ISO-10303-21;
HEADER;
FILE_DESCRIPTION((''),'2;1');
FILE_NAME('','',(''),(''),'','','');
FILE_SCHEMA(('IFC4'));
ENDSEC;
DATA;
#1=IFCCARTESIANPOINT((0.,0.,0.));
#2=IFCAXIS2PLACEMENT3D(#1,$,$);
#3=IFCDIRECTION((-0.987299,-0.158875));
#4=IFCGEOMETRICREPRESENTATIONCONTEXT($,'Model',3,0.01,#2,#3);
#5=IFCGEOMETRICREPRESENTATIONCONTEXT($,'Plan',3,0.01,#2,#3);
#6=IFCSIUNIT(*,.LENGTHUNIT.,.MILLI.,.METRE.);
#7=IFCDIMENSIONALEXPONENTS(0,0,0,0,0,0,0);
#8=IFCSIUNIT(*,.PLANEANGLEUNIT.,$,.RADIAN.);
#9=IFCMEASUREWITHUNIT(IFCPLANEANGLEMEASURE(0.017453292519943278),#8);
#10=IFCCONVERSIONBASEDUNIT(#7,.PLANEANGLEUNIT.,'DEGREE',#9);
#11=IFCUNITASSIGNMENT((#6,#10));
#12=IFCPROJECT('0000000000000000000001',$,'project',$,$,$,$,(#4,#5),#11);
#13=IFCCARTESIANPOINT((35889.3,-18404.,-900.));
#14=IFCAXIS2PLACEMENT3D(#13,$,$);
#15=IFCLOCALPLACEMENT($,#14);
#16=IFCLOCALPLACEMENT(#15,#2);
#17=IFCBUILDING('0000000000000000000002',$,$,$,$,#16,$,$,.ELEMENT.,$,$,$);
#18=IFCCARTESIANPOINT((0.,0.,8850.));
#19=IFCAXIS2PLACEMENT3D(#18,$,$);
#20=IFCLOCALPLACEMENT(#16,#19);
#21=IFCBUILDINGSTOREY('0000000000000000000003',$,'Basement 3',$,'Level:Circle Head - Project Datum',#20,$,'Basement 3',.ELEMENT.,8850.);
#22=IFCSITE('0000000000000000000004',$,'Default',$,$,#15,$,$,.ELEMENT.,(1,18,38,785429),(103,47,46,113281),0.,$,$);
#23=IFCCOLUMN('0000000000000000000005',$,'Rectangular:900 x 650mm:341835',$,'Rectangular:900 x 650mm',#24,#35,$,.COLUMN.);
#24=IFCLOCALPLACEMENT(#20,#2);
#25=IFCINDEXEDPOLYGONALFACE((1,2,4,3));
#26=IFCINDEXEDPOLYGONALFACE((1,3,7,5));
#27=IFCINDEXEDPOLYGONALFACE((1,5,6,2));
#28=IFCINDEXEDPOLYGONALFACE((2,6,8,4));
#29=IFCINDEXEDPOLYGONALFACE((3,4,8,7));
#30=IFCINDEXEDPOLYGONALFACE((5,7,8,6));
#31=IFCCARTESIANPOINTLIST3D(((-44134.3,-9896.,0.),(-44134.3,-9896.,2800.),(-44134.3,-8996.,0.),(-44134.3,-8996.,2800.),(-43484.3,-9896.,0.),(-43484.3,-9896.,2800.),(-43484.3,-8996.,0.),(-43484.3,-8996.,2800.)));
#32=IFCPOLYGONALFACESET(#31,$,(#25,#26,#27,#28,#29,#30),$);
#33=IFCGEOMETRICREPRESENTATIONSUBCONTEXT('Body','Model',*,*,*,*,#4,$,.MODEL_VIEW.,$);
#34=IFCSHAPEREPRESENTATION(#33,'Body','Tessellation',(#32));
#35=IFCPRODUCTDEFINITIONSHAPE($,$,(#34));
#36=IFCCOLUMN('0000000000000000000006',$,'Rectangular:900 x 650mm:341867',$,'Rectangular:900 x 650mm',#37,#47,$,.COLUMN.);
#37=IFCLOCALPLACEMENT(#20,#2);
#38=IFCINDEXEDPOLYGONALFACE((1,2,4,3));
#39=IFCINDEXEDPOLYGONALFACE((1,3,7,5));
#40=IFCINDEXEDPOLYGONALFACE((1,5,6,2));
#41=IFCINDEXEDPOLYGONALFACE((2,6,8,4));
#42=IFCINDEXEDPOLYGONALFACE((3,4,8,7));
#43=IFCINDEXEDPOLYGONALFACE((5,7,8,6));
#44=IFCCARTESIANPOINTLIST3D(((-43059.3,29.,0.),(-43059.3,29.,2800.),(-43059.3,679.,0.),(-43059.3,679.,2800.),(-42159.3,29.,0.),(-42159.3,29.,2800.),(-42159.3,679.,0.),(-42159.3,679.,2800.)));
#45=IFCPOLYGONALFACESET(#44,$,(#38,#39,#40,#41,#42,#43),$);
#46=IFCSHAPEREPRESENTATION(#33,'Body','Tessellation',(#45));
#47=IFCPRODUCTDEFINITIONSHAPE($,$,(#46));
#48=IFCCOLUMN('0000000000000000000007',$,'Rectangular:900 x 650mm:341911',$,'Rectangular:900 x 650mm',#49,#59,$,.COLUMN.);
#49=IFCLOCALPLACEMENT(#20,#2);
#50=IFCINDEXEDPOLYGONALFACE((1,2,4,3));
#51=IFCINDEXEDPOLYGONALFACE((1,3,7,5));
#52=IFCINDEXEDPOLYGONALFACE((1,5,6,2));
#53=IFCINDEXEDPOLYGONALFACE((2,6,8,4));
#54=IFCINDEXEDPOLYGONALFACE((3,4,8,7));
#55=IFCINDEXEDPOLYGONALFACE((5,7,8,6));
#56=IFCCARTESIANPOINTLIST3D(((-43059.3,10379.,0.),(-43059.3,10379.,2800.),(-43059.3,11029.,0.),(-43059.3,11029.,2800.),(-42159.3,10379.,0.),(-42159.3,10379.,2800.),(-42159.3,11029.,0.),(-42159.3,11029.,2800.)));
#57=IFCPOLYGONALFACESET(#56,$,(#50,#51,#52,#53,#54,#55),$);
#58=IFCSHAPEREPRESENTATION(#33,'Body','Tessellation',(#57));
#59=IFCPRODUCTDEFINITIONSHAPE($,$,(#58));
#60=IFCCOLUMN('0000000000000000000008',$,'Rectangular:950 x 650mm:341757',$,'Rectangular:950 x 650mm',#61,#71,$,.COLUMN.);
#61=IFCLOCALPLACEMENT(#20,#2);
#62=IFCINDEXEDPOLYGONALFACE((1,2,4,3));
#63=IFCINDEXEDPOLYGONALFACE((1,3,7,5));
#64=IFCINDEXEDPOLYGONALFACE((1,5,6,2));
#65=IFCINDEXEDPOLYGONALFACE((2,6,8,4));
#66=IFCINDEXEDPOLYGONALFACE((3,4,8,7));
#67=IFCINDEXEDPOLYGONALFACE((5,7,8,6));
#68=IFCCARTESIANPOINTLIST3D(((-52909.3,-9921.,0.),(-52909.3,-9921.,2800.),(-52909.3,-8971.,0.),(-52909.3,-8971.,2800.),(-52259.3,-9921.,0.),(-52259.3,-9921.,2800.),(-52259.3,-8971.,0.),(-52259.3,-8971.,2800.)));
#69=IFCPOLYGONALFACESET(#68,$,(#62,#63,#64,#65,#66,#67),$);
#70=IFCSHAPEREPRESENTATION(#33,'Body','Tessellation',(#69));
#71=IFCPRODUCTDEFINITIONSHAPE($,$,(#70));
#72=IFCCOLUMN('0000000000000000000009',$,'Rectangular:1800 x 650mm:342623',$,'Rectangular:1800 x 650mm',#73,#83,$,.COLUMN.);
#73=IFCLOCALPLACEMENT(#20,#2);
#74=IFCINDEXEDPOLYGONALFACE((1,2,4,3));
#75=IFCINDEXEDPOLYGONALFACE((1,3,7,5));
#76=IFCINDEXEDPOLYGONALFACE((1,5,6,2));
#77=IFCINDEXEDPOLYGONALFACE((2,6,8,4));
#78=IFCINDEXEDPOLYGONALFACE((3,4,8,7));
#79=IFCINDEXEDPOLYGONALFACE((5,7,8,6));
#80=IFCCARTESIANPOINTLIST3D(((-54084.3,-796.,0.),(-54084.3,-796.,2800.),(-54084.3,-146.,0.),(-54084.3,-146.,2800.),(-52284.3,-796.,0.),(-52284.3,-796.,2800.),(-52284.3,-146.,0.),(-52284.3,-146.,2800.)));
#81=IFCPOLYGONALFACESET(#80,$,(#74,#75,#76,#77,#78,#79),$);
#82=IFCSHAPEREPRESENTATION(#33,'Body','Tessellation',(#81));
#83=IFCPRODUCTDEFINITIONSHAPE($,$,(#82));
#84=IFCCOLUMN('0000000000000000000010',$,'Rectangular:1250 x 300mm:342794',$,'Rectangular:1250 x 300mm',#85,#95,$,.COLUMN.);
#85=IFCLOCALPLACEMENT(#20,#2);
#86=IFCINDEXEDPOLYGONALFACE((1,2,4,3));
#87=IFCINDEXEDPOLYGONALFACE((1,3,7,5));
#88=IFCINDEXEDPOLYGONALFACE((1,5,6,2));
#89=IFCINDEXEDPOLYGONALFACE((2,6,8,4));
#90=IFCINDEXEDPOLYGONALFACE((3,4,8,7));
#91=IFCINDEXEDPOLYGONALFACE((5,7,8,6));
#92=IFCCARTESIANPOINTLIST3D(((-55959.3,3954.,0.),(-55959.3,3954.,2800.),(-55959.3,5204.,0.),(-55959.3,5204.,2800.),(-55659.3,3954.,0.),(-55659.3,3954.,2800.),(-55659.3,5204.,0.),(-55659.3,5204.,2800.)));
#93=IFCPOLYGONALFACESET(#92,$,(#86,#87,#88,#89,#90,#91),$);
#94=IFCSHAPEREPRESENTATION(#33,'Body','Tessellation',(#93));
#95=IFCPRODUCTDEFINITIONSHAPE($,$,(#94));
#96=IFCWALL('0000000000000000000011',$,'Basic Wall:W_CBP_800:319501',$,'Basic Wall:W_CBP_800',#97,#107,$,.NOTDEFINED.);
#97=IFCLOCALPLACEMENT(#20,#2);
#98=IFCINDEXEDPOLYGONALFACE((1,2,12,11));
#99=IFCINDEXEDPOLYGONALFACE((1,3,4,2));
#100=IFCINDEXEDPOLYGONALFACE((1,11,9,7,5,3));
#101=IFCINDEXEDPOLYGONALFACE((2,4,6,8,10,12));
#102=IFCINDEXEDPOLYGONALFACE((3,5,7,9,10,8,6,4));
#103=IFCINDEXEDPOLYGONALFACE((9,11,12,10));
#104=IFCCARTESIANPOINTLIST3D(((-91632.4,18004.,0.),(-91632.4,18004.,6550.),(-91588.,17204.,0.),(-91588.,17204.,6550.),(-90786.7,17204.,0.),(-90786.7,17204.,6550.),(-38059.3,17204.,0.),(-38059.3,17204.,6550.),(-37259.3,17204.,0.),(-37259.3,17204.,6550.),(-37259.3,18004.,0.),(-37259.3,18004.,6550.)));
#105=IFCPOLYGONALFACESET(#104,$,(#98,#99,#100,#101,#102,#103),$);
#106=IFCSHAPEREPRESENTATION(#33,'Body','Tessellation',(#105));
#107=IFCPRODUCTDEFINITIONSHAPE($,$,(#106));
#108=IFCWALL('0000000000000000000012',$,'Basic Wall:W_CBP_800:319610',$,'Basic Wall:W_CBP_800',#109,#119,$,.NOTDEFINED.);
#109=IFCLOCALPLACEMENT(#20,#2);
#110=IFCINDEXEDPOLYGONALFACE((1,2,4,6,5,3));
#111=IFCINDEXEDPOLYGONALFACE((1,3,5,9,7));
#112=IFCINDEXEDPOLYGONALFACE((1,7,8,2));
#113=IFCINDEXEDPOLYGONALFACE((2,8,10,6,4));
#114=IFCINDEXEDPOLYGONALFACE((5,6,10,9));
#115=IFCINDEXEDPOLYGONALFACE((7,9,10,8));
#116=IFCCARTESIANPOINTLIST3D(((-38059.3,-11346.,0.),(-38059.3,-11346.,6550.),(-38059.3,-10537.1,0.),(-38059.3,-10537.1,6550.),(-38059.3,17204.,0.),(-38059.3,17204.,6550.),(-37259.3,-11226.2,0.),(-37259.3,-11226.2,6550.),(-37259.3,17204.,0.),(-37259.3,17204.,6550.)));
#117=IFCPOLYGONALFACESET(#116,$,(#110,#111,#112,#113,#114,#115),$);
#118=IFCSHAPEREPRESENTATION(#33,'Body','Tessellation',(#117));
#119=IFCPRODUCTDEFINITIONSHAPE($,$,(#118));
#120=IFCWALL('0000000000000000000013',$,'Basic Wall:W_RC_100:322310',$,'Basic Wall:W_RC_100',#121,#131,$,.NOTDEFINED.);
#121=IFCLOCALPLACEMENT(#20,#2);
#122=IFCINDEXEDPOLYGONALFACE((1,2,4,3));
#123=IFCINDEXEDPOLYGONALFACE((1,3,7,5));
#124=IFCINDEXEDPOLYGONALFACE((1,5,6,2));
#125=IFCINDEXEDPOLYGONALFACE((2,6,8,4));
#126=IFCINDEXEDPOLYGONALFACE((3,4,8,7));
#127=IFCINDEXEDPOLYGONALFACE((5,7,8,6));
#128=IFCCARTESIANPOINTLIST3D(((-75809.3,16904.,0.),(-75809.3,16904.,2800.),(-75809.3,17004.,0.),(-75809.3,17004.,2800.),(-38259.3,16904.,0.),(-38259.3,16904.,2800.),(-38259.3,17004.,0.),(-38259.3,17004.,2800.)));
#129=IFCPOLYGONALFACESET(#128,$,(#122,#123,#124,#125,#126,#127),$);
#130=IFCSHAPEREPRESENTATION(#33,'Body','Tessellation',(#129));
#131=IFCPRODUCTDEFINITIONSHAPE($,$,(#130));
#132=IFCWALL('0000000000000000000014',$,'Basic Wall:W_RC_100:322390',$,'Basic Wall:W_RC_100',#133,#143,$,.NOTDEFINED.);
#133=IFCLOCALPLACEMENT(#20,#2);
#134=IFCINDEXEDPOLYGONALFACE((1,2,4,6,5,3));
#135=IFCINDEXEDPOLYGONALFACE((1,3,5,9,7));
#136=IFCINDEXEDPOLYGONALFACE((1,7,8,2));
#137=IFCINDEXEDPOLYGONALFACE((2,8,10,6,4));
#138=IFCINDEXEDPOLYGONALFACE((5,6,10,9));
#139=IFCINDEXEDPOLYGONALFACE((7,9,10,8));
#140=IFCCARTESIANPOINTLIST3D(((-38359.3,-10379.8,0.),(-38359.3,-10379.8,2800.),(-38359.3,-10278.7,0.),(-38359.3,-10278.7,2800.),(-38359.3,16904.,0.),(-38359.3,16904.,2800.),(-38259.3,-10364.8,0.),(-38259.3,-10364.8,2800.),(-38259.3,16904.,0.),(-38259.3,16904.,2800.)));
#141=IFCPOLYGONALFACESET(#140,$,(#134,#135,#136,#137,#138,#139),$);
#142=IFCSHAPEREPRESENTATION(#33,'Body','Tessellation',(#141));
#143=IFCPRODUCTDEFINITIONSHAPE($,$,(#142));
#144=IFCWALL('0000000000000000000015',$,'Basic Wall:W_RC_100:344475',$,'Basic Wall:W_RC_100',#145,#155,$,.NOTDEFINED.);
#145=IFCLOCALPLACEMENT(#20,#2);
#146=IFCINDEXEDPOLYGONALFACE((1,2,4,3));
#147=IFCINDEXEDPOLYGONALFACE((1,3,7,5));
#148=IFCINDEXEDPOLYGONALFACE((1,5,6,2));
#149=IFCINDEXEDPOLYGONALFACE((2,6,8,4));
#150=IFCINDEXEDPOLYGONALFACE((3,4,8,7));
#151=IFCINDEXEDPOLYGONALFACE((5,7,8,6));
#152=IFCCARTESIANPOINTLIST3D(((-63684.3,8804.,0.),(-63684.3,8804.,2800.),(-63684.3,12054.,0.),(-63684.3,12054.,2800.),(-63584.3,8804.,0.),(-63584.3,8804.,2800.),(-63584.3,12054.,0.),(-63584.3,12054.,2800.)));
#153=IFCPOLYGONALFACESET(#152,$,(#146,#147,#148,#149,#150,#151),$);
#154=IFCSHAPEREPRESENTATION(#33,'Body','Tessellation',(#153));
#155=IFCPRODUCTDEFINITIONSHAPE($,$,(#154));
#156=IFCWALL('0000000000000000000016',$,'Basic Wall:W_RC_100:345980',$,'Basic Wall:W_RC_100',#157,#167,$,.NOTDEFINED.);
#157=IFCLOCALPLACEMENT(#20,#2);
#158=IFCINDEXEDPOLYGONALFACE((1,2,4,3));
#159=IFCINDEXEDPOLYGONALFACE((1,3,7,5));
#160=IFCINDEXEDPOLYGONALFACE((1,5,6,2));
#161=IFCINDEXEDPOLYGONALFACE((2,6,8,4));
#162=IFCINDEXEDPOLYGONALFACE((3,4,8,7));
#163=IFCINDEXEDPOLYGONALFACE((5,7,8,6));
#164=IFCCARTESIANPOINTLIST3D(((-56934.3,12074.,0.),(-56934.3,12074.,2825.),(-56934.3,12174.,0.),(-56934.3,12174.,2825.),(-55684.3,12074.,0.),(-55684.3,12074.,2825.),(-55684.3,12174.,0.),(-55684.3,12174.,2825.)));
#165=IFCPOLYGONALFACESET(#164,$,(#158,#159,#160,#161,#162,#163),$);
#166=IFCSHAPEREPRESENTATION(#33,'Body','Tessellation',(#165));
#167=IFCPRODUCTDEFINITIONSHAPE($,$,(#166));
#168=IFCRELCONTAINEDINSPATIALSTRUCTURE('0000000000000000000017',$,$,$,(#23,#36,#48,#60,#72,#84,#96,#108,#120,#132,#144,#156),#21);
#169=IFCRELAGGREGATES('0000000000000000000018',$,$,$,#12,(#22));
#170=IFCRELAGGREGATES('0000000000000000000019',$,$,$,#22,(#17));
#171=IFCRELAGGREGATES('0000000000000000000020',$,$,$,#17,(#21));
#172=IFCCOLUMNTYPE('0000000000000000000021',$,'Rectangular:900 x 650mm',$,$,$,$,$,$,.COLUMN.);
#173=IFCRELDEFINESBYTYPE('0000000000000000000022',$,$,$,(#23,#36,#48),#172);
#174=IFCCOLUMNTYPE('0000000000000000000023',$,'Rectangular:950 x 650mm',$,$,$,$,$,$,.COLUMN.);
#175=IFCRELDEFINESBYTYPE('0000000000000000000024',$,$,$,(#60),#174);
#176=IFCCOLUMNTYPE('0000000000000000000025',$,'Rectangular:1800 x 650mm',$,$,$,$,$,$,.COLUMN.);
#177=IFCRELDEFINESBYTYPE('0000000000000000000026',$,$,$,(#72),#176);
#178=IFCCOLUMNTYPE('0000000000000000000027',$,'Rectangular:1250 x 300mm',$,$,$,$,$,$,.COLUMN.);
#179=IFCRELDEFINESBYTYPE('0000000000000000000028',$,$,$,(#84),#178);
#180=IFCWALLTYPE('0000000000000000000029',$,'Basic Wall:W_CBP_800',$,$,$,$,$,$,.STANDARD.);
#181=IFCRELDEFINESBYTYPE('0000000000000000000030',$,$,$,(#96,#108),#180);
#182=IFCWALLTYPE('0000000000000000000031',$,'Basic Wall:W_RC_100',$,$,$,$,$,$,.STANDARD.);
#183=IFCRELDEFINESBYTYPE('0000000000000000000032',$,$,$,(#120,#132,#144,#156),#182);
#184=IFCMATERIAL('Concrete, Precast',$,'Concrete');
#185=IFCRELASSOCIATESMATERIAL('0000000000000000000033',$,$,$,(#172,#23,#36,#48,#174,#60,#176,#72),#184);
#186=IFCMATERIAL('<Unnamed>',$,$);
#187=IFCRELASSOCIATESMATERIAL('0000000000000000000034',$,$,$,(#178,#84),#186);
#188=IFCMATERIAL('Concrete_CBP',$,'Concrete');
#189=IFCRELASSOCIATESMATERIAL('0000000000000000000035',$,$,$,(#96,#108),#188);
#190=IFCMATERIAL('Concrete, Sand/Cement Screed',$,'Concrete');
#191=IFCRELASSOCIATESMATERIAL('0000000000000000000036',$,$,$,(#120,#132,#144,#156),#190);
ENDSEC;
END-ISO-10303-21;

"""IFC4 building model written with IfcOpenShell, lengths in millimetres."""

from ifc_helpers import new_model, entity, si_unit, converted_unit, direction, frame, origin, place, context, subcontext, project, spatial, indexed_curve, outline, extrude, source, transform, mapped, material, type_object, type_shapes, element, save


model = new_model("IFC4")

# Units and contexts
model_context = context("Model", 3, precision=0.01, world=origin(), true_north=direction((-0.987299, -0.158875)))
plan_context = context("Plan", 3, precision=0.01, world=origin(), true_north=direction((-0.987299, -0.158875)))
body_context = subcontext(model_context, "Body", "Model", "MODEL_VIEW")
ifc_project = project(units=[si_unit("LENGTHUNIT", "METRE", prefix="MILLI"), converted_unit("PLANEANGLEUNIT", "DEGREE", entity("IfcPlaneAngleMeasure", 0.017453292519943278), si_unit("PLANEANGLEUNIT", "RADIAN"), dimensions=[0, 0, 0, 0, 0, 0, 0])], contexts=[model_context, plan_context])

# Site, building, storey
site_placement = place(None, frame((35889.3, -18404.0, -900.0)))
site = spatial("IfcSite", under=ifc_project, at=site_placement, Name="Default", CompositionType="ELEMENT", RefLatitude=(1, 18, 38, 785429), RefLongitude=(103, 47, 46, 113281), RefElevation=0.0)
building_placement = place(site_placement, origin())
building = spatial("IfcBuilding", under=site, at=building_placement, CompositionType="ELEMENT")
storey_placement = place(building_placement, frame((0.0, 0.0, 8850.0)))
storey = spatial("IfcBuildingStorey", under=building, at=storey_placement, Name="Basement 3", ObjectType="Level:Circle Head - Project Datum", LongName="Basement 3", CompositionType="ELEMENT", Elevation=8850.0)

# Columns
ifc_material_1 = material(Name="Concrete, Precast", Category="Concrete")
column_type_1 = type_object("IfcColumnType", Name="Rectangular:900 x 650mm", PredefinedType="COLUMN", material=ifc_material_1)
shared_shape_1 = source(origin(), body_context, "Body", "SweptSolid", [
    extrude(outline(indexed_curve([(-325.0, -450.0), (325.0, -450.0), (325.0, 450.0), (-325.0, 450.0), (-325.0, -450.0)], self_intersect=False)), frame((0.0, 0.0, 8850.0), z_axis=(0.0, 0.0, 1.0), x_axis=(-1.0, 0.0, 0.0)), (0.0, 0.0, 1.0), 2800.0),
])
type_shapes(column_type_1, [shared_shape_1])
column_1_placement = place(storey_placement, frame((-43809.3, -9446.0, -8850.0)))
element("IfcColumn", 1, at=column_1_placement, inside=storey, type_object=column_type_1, material=ifc_material_1, Name="Rectangular:900 x 650mm:341835", ObjectType="Rectangular:900 x 650mm", PredefinedType="COLUMN", context=body_context, shape_type="MappedRepresentation", body=[
    mapped(shared_shape_1, transform((0.0, 0.0, 0.0), scale=1.0)),
])
for number, where, z_axis, x_axis, name in (
    (2, (-42609.3, 354.0, -8850.0), (0.0, 0.0, 1.0), (0.0, 1.0, 0.0), "Rectangular:900 x 650mm:341867"),
    (3, (-42609.3, 10704.0, -8850.0), (0.0, 0.0, 1.0), (0.0, 1.0, 0.0), "Rectangular:900 x 650mm:341911"),
):
    element("IfcColumn", number, at=place(storey_placement, frame(where, z_axis=z_axis, x_axis=x_axis)), inside=storey, type_object=column_type_1, material=ifc_material_1, Name=name, ObjectType="Rectangular:900 x 650mm", PredefinedType="COLUMN", context=body_context, shape_type="MappedRepresentation", body=[
        mapped(shared_shape_1, transform((0.0, 0.0, 0.0), scale=1.0)),
    ])
column_type_2 = type_object("IfcColumnType", Name="Rectangular:950 x 650mm", PredefinedType="COLUMN", material=ifc_material_1)
shared_shape_2 = source(origin(), body_context, "Body", "SweptSolid", [
    extrude(outline(indexed_curve([(-325.0, -475.0), (325.0, -475.0), (325.0, 475.0), (-325.0, 475.0), (-325.0, -475.0)], self_intersect=False)), frame((0.0, 0.0, 8850.0), z_axis=(0.0, 0.0, 1.0), x_axis=(-1.0, 0.0, 0.0)), (0.0, 0.0, 1.0), 2800.0),
])
type_shapes(column_type_2, [shared_shape_2])
column_2_placement = place(storey_placement, frame((-52584.3, -9446.0, -8850.0)))
element("IfcColumn", 4, at=column_2_placement, inside=storey, type_object=column_type_2, material=ifc_material_1, Name="Rectangular:950 x 650mm:341757", ObjectType="Rectangular:950 x 650mm", PredefinedType="COLUMN", context=body_context, shape_type="MappedRepresentation", body=[
    mapped(shared_shape_2, transform((0.0, 0.0, 0.0), scale=1.0)),
])
column_type_3 = type_object("IfcColumnType", Name="Rectangular:1800 x 650mm", PredefinedType="COLUMN", material=ifc_material_1)
shared_shape_3 = source(origin(), body_context, "Body", "SweptSolid", [
    extrude(outline(indexed_curve([(-325.0, -900.0), (325.0, -900.0), (325.0, 900.0), (-325.0, 900.0), (-325.0, -900.0)], self_intersect=False)), frame((0.0, 0.0, 8850.0), z_axis=(0.0, 0.0, 1.0), x_axis=(-1.0, 0.0, 0.0)), (0.0, 0.0, 1.0), 2800.0),
])
type_shapes(column_type_3, [shared_shape_3])
column_3_placement = place(storey_placement, frame((-53184.3, -471.0, -8850.0), z_axis=(0.0, 0.0, 1.0), x_axis=(0.0, 1.0, 0.0)))
element("IfcColumn", 5, at=column_3_placement, inside=storey, type_object=column_type_3, material=ifc_material_1, Name="Rectangular:1800 x 650mm:342623", ObjectType="Rectangular:1800 x 650mm", PredefinedType="COLUMN", context=body_context, shape_type="MappedRepresentation", body=[
    mapped(shared_shape_3, transform((0.0, 0.0, 0.0), scale=1.0)),
])
ifc_material_2 = material(Name="<Unnamed>")
column_type_4 = type_object("IfcColumnType", Name="Rectangular:1250 x 300mm", PredefinedType="COLUMN", material=ifc_material_2)
shared_shape_4 = source(origin(), body_context, "Body", "SweptSolid", [
    extrude(outline(indexed_curve([(-150.0, -625.0), (150.0, -625.0), (150.0, 625.0), (-150.0, 625.0), (-150.0, -625.0)], self_intersect=False)), frame((0.0, 0.0, 8850.0), z_axis=(0.0, 0.0, 1.0), x_axis=(-1.0, 0.0, 0.0)), (0.0, 0.0, 1.0), 2800.0),
])
type_shapes(column_type_4, [shared_shape_4])
column_4_placement = place(storey_placement, frame((-55809.3, 4579.0, -8850.0), z_axis=(0.0, 0.0, 1.0), x_axis=(-1.0, 0.0, 0.0)))
element("IfcColumn", 6, at=column_4_placement, inside=storey, type_object=column_type_4, material=ifc_material_2, Name="Rectangular:1250 x 300mm:342794", ObjectType="Rectangular:1250 x 300mm", PredefinedType="COLUMN", context=body_context, shape_type="MappedRepresentation", body=[
    mapped(shared_shape_4, transform((0.0, 0.0, 0.0), scale=1.0)),
])

# Walls
ifc_material_3 = material(Name="Concrete_CBP", Category="Concrete")
wall_type_1 = type_object("IfcWallType", Name="Basic Wall:W_CBP_800", PredefinedType="STANDARD")
wall_1_placement = place(storey_placement, frame((-37259.3, 17604.0, 0.0), z_axis=(0.0, 0.0, 1.0), x_axis=(-1.0, 0.0, 0.0)))
element("IfcWall", 7, at=wall_1_placement, inside=storey, type_object=wall_type_1, material=ifc_material_3, Name="Basic Wall:W_CBP_800:319501", ObjectType="Basic Wall:W_CBP_800", PredefinedType="NOTDEFINED", context=body_context, shape_type="SweptSolid", body=[
    extrude(outline(indexed_curve([(54373.1, -400.0), (54328.6, 400.0), (53527.4, 400.0), (800.0, 400.0), (0.0, 400.0), (0.0, -400.0), (54373.1, -400.0)], self_intersect=False)), origin(), (0.0, 0.0, 1.0), 6550.0),
])
wall_2_placement = place(storey_placement, frame((-37659.3, 17204.0, 0.0), z_axis=(0.0, 0.0, 1.0), x_axis=(0.0, -1.0, 0.0)))
element("IfcWall", 8, at=wall_2_placement, inside=storey, type_object=wall_type_1, material=ifc_material_3, Name="Basic Wall:W_CBP_800:319610", ObjectType="Basic Wall:W_CBP_800", PredefinedType="NOTDEFINED", context=body_context, shape_type="SweptSolid", body=[
    extrude(outline(indexed_curve([(28550.1, -400.0), (28430.2, 400.0), (0.0, 400.0), (0.0, -400.0), (27741.1, -400.0), (28550.1, -400.0)], self_intersect=False)), origin(), (0.0, 0.0, 1.0), 6550.0),
])
ifc_material_4 = material(Name="Concrete, Sand/Cement Screed", Category="Concrete")
wall_type_2 = type_object("IfcWallType", Name="Basic Wall:W_RC_100", PredefinedType="STANDARD")
wall_3_placement = place(storey_placement, frame((-38259.3, 16954.0, 0.0), z_axis=(0.0, 0.0, 1.0), x_axis=(-1.0, 0.0, 0.0)))
element("IfcWall", 9, at=wall_3_placement, inside=storey, type_object=wall_type_2, material=ifc_material_4, Name="Basic Wall:W_RC_100:322310", ObjectType="Basic Wall:W_RC_100", PredefinedType="NOTDEFINED", context=body_context, shape_type="SweptSolid", body=[
    extrude(outline(indexed_curve([(37550.0, 50.0), (0.0, 50.0), (0.0, -50.0), (37550.0, -50.0), (37550.0, 50.0)], self_intersect=False)), origin(), (0.0, 0.0, 1.0), 2800.0),
])
wall_4_placement = place(storey_placement, frame((-38309.3, 16904.0, 0.0), z_axis=(0.0, 0.0, 1.0), x_axis=(0.0, -1.0, 0.0)))
element("IfcWall", 10, at=wall_4_placement, inside=storey, type_object=wall_type_2, material=ifc_material_4, Name="Basic Wall:W_RC_100:322390", ObjectType="Basic Wall:W_RC_100", PredefinedType="NOTDEFINED", context=body_context, shape_type="SweptSolid", body=[
    extrude(outline(indexed_curve([(27283.8, -50.0), (27268.9, 50.0), (0.0, 50.0), (0.0, -50.0), (27182.7, -50.0), (27283.8, -50.0)], self_intersect=False)), origin(), (0.0, 0.0, 1.0), 2800.0),
])
wall_5_placement = place(storey_placement, frame((-63634.3, 12054.0, 0.0), z_axis=(0.0, 0.0, 1.0), x_axis=(0.0, -1.0, 0.0)))
element("IfcWall", 11, at=wall_5_placement, inside=storey, type_object=wall_type_2, material=ifc_material_4, Name="Basic Wall:W_RC_100:344475", ObjectType="Basic Wall:W_RC_100", PredefinedType="NOTDEFINED", context=body_context, shape_type="SweptSolid", body=[
    extrude(outline(indexed_curve([(3250.0, 50.0), (0.0, 50.0), (0.0, -50.0), (3250.0, -50.0), (3250.0, 50.0)], self_intersect=False)), origin(), (0.0, 0.0, 1.0), 2800.0),
])
wall_6_placement = place(storey_placement, frame((-56934.3, 12124.0, 0.0)))
element("IfcWall", 12, at=wall_6_placement, inside=storey, type_object=wall_type_2, material=ifc_material_4, Name="Basic Wall:W_RC_100:345980", ObjectType="Basic Wall:W_RC_100", PredefinedType="NOTDEFINED", context=body_context, shape_type="SweptSolid", body=[
    extrude(outline(indexed_curve([(1250.0, 50.0), (0.0, 50.0), (0.0, -50.0), (1250.0, -50.0), (1250.0, 50.0)], self_intersect=False)), origin(), (0.0, 0.0, 1.0), 2825.0),
])

save(model, "model.ifc")
